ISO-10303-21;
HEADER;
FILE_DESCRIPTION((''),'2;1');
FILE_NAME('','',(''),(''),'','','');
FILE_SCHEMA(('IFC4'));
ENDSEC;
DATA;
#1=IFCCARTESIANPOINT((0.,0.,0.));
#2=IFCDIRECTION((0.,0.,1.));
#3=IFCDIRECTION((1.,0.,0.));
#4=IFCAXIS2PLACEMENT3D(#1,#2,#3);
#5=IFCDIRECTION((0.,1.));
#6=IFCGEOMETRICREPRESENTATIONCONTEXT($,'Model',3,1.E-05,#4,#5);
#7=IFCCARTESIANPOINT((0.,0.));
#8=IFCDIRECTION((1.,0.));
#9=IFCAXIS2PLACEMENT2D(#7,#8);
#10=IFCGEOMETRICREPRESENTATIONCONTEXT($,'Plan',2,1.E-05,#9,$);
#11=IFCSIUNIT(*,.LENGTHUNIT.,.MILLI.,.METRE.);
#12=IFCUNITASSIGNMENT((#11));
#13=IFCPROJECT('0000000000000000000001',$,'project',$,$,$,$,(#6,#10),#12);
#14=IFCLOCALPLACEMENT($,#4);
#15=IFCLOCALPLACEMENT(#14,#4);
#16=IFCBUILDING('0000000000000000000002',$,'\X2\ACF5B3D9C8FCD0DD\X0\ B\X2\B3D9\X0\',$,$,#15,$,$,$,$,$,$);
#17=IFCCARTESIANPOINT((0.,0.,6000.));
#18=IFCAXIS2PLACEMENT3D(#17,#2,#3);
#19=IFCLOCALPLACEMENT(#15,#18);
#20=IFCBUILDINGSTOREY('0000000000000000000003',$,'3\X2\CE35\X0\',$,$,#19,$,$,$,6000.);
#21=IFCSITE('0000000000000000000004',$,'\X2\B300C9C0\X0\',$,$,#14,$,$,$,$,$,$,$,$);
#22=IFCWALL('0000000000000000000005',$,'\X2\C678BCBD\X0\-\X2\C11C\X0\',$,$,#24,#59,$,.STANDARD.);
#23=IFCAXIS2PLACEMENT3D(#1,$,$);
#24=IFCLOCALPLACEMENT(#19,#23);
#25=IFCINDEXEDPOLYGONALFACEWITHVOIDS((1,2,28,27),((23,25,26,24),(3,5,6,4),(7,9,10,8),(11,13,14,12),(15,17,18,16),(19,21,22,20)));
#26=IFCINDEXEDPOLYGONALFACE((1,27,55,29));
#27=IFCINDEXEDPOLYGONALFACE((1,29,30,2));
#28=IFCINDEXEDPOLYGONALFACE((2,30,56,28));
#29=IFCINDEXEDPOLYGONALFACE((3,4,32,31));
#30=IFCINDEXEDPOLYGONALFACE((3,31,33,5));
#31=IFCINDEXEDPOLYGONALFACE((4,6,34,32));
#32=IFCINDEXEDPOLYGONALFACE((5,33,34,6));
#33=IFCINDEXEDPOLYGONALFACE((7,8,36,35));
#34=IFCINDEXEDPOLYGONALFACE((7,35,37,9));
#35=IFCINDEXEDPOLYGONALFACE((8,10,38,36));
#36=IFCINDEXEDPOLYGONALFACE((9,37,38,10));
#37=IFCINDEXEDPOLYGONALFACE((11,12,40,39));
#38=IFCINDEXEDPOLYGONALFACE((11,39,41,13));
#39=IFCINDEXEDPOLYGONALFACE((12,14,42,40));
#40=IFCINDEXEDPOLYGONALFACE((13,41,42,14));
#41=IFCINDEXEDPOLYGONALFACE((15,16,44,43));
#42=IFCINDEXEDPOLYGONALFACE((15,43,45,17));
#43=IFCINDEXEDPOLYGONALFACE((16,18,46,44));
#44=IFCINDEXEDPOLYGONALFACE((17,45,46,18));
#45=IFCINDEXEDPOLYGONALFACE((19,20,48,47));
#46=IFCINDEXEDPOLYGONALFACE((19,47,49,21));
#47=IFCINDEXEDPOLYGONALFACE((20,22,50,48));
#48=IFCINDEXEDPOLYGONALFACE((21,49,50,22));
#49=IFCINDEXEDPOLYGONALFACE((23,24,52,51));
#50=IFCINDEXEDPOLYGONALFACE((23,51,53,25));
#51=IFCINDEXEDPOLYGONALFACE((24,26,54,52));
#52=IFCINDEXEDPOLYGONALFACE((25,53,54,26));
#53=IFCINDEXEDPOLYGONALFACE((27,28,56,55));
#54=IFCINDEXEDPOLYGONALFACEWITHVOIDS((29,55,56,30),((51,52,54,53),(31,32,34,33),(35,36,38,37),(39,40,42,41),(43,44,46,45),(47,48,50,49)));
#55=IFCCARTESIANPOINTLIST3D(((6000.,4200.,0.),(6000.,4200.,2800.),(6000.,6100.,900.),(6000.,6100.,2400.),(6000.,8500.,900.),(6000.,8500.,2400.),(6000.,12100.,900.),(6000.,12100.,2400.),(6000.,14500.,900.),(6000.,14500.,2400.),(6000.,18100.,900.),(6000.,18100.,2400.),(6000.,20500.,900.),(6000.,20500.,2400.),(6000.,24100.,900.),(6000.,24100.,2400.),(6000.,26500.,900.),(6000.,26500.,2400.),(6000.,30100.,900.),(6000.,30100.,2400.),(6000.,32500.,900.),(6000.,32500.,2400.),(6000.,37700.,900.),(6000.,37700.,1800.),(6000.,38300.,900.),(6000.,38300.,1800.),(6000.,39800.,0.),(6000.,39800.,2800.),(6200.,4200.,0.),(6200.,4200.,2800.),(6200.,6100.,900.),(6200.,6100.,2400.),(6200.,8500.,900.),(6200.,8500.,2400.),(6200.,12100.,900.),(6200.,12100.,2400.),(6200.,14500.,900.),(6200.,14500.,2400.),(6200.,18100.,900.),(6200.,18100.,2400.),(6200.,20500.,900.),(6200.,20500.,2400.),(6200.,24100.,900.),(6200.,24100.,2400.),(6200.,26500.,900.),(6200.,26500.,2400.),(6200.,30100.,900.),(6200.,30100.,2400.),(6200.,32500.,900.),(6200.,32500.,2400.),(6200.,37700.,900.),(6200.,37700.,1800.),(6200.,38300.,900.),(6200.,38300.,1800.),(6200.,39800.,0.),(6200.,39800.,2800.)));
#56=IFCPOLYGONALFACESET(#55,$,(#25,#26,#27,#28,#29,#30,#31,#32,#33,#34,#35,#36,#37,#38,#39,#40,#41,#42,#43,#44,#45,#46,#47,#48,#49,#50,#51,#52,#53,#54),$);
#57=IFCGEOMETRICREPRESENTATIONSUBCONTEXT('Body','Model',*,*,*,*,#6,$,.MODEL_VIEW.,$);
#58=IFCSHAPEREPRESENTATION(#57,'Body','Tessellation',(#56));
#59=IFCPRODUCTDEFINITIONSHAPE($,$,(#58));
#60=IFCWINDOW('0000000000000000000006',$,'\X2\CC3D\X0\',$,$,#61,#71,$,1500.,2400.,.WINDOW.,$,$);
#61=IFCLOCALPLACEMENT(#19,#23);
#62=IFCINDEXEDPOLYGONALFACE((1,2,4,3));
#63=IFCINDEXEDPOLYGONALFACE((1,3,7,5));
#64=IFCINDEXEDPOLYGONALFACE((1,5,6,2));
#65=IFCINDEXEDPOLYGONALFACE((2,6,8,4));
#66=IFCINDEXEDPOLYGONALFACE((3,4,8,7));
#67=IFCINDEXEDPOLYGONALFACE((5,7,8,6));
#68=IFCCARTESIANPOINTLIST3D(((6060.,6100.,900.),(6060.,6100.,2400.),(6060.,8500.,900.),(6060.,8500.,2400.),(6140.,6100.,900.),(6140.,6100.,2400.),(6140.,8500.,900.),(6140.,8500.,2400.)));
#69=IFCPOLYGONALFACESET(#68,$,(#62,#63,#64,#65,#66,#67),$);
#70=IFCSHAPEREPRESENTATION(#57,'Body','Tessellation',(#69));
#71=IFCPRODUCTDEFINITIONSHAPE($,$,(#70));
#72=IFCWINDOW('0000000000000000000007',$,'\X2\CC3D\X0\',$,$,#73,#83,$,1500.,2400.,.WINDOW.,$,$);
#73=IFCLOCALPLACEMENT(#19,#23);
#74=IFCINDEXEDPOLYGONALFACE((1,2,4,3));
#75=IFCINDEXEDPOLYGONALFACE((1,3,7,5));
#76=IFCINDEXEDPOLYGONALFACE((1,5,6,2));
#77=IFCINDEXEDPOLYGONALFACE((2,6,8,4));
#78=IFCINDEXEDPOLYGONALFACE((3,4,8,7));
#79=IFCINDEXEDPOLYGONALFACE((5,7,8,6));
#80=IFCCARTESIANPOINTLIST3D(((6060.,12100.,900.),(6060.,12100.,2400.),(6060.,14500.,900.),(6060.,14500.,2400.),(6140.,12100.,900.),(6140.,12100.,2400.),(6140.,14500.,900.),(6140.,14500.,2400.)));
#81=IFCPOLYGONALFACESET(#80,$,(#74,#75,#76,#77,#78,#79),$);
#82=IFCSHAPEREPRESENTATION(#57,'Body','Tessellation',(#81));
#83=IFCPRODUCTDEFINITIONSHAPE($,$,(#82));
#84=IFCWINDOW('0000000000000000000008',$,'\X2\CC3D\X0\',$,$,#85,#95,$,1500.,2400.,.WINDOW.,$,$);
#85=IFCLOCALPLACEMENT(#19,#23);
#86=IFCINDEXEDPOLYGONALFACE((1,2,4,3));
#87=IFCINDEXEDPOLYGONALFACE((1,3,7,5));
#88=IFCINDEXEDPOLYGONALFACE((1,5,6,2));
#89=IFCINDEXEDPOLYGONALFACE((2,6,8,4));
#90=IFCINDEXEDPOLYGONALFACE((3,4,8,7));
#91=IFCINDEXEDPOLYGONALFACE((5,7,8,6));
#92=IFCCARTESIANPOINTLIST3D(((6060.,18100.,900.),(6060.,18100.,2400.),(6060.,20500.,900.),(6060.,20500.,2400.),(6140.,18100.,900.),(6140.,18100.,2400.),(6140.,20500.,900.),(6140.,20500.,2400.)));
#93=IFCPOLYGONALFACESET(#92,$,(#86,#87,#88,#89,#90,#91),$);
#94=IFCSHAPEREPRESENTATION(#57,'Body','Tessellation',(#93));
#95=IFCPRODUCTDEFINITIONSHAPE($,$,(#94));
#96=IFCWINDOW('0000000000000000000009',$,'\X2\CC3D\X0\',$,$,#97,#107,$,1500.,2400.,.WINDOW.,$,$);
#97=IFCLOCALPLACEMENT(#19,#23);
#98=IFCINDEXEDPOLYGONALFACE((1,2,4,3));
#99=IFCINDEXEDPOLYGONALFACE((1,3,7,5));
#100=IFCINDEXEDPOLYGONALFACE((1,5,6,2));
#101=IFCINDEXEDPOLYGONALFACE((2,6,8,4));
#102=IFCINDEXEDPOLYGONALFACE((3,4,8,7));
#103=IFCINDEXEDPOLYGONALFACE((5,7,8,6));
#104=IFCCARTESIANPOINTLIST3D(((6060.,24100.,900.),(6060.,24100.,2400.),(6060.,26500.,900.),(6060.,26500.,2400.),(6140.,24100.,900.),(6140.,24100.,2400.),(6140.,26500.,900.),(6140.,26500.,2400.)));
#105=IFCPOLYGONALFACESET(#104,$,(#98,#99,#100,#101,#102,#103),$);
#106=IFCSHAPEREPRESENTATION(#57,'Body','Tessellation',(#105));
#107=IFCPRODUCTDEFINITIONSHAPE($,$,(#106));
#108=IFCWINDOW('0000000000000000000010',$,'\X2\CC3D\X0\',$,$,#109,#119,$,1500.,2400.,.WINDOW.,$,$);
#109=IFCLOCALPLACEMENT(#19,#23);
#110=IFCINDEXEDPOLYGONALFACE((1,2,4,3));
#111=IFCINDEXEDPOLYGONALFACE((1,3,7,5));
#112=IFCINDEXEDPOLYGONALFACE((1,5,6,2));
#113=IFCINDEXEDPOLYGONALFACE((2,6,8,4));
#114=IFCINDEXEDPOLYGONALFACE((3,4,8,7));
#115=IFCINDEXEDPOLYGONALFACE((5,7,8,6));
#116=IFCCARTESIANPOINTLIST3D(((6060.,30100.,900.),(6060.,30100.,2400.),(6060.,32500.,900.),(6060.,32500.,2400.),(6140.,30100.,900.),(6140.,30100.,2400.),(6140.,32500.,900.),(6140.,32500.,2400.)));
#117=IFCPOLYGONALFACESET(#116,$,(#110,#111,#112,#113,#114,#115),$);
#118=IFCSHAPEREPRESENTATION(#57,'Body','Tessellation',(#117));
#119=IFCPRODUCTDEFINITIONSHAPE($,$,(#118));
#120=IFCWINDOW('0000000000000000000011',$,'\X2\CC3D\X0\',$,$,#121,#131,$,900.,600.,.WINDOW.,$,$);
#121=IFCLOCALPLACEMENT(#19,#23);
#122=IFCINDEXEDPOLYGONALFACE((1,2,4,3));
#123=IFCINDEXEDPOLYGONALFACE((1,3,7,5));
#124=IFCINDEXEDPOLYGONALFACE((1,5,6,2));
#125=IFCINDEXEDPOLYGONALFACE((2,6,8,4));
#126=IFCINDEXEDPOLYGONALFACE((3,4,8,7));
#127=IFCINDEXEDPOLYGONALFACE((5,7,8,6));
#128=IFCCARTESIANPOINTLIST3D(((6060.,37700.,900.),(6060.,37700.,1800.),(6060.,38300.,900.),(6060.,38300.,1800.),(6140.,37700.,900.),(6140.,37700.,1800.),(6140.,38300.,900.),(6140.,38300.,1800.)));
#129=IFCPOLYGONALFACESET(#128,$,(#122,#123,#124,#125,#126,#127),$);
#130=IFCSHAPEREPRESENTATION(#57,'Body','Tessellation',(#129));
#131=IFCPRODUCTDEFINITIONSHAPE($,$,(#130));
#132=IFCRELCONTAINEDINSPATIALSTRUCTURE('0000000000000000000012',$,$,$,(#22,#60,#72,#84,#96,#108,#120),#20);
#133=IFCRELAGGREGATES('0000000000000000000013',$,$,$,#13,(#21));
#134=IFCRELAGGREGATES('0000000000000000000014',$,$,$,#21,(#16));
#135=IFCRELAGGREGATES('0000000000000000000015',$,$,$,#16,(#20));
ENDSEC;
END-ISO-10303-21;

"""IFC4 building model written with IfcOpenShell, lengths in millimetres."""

from ifc_helpers import new_model, si_unit, direction, frame, origin_with_axes, origin_2d_with_axis, place, context, subcontext, project, spatial, polyline, outline, extrude, element, fill, save


model = new_model("IFC4")

# Units and contexts
model_context = context("Model", 3, precision=1e-05, world=origin_with_axes(), true_north=direction((0.0, 1.0)))
plan_context = context("Plan", 2, precision=1e-05, world=origin_2d_with_axis())
body_context = subcontext(model_context, "Body", "Model", "MODEL_VIEW")
ifc_project = project(units=[si_unit("LENGTHUNIT", "METRE", prefix="MILLI")], contexts=[model_context, plan_context])

# Site, building, storey
site_placement = place(None, origin_with_axes())
site = spatial("IfcSite", under=ifc_project, at=site_placement, Name="대지")
building_placement = place(site_placement, origin_with_axes())
building = spatial("IfcBuilding", under=site, at=building_placement, Name="공동주택 B동")
storey_placement = place(building_placement, frame((0.0, 0.0, 6000.0), z_axis=(0.0, 0.0, 1.0), x_axis=(1.0, 0.0, 0.0)))
storey = spatial("IfcBuildingStorey", under=building, at=storey_placement, Name="3층", Elevation=6000.0)

# Wall, openings, windows
wall_1_placement = place(storey_placement, origin_with_axes())
wall_1 = element("IfcWall", 1, at=wall_1_placement, inside=storey, Name="외벽-서", PredefinedType="STANDARD", context=body_context, shape_type="SweptSolid", body=[
    extrude(outline(polyline([(6200.0, 39800.0), (6200.0, 4200.0), (6000.0, 4200.0), (6000.0, 39800.0), (6200.0, 39800.0)])), origin_with_axes(), (0.0, 0.0, 1.0), 2800.0),
])
opening_1_placement = place(storey_placement, origin_with_axes())
opening_1 = element("IfcOpeningElement", 2, at=opening_1_placement, cuts=wall_1, PredefinedType="OPENING", context=body_context, shape_type="SweptSolid", body=[
    extrude(outline(polyline([(5950.0, 8500.0), (5950.0, 6100.0), (6250.0, 6100.0), (6250.0, 8500.0), (5950.0, 8500.0)])), frame((0.0, 0.0, 900.0), z_axis=(0.0, 0.0, 1.0), x_axis=(1.0, 0.0, 0.0)), (0.0, 0.0, 1.0), 1500.0),
])
opening_2_placement = place(storey_placement, origin_with_axes())
opening_2 = element("IfcOpeningElement", 3, at=opening_2_placement, cuts=wall_1, PredefinedType="OPENING", context=body_context, shape_type="SweptSolid", body=[
    extrude(outline(polyline([(5950.0, 14500.0), (5950.0, 12100.0), (6250.0, 12100.0), (6250.0, 14500.0), (5950.0, 14500.0)])), frame((0.0, 0.0, 900.0), z_axis=(0.0, 0.0, 1.0), x_axis=(1.0, 0.0, 0.0)), (0.0, 0.0, 1.0), 1500.0),
])
opening_3_placement = place(storey_placement, origin_with_axes())
opening_3 = element("IfcOpeningElement", 4, at=opening_3_placement, cuts=wall_1, PredefinedType="OPENING", context=body_context, shape_type="SweptSolid", body=[
    extrude(outline(polyline([(5950.0, 20500.0), (5950.0, 18100.0), (6250.0, 18100.0), (6250.0, 20500.0), (5950.0, 20500.0)])), frame((0.0, 0.0, 900.0), z_axis=(0.0, 0.0, 1.0), x_axis=(1.0, 0.0, 0.0)), (0.0, 0.0, 1.0), 1500.0),
])
opening_4_placement = place(storey_placement, origin_with_axes())
opening_4 = element("IfcOpeningElement", 5, at=opening_4_placement, cuts=wall_1, PredefinedType="OPENING", context=body_context, shape_type="SweptSolid", body=[
    extrude(outline(polyline([(5950.0, 26500.0), (5950.0, 24100.0), (6250.0, 24100.0), (6250.0, 26500.0), (5950.0, 26500.0)])), frame((0.0, 0.0, 900.0), z_axis=(0.0, 0.0, 1.0), x_axis=(1.0, 0.0, 0.0)), (0.0, 0.0, 1.0), 1500.0),
])
opening_5_placement = place(storey_placement, origin_with_axes())
opening_5 = element("IfcOpeningElement", 6, at=opening_5_placement, cuts=wall_1, PredefinedType="OPENING", context=body_context, shape_type="SweptSolid", body=[
    extrude(outline(polyline([(5950.0, 32500.0), (5950.0, 30100.0), (6250.0, 30100.0), (6250.0, 32500.0), (5950.0, 32500.0)])), frame((0.0, 0.0, 900.0), z_axis=(0.0, 0.0, 1.0), x_axis=(1.0, 0.0, 0.0)), (0.0, 0.0, 1.0), 1500.0),
])
opening_6_placement = place(storey_placement, origin_with_axes())
opening_6 = element("IfcOpeningElement", 7, at=opening_6_placement, cuts=wall_1, PredefinedType="OPENING", context=body_context, shape_type="SweptSolid", body=[
    extrude(outline(polyline([(5950.0, 38300.0), (5950.0, 37700.0), (6250.0, 37700.0), (6250.0, 38300.0), (5950.0, 38300.0)])), frame((0.0, 0.0, 900.0), z_axis=(0.0, 0.0, 1.0), x_axis=(1.0, 0.0, 0.0)), (0.0, 0.0, 1.0), 900.0),
])
window_1_placement = place(storey_placement, origin_with_axes())
window_1 = element("IfcWindow", 8, at=window_1_placement, inside=storey, Name="창", OverallHeight=1500.0, OverallWidth=2400.0, PredefinedType="WINDOW", context=body_context, shape_type="SweptSolid", body=[
    extrude(outline(polyline([(6060.0, 8500.0), (6060.0, 6100.0), (6140.0, 6100.0), (6140.0, 8500.0), (6060.0, 8500.0)])), frame((0.0, 0.0, 900.0), z_axis=(0.0, 0.0, 1.0), x_axis=(1.0, 0.0, 0.0)), (0.0, 0.0, 1.0), 1500.0),
])
fill(opening_1, window_1)
window_2_placement = place(storey_placement, origin_with_axes())
window_2 = element("IfcWindow", 9, at=window_2_placement, inside=storey, Name="창", OverallHeight=1500.0, OverallWidth=2400.0, PredefinedType="WINDOW", context=body_context, shape_type="SweptSolid", body=[
    extrude(outline(polyline([(6060.0, 14500.0), (6060.0, 12100.0), (6140.0, 12100.0), (6140.0, 14500.0), (6060.0, 14500.0)])), frame((0.0, 0.0, 900.0), z_axis=(0.0, 0.0, 1.0), x_axis=(1.0, 0.0, 0.0)), (0.0, 0.0, 1.0), 1500.0),
])
fill(opening_2, window_2)
window_3_placement = place(storey_placement, origin_with_axes())
window_3 = element("IfcWindow", 10, at=window_3_placement, inside=storey, Name="창", OverallHeight=1500.0, OverallWidth=2400.0, PredefinedType="WINDOW", context=body_context, shape_type="SweptSolid", body=[
    extrude(outline(polyline([(6060.0, 20500.0), (6060.0, 18100.0), (6140.0, 18100.0), (6140.0, 20500.0), (6060.0, 20500.0)])), frame((0.0, 0.0, 900.0), z_axis=(0.0, 0.0, 1.0), x_axis=(1.0, 0.0, 0.0)), (0.0, 0.0, 1.0), 1500.0),
])
fill(opening_3, window_3)
window_4_placement = place(storey_placement, origin_with_axes())
window_4 = element("IfcWindow", 11, at=window_4_placement, inside=storey, Name="창", OverallHeight=1500.0, OverallWidth=2400.0, PredefinedType="WINDOW", context=body_context, shape_type="SweptSolid", body=[
    extrude(outline(polyline([(6060.0, 26500.0), (6060.0, 24100.0), (6140.0, 24100.0), (6140.0, 26500.0), (6060.0, 26500.0)])), frame((0.0, 0.0, 900.0), z_axis=(0.0, 0.0, 1.0), x_axis=(1.0, 0.0, 0.0)), (0.0, 0.0, 1.0), 1500.0),
])
fill(opening_4, window_4)
window_5_placement = place(storey_placement, origin_with_axes())
window_5 = element("IfcWindow", 12, at=window_5_placement, inside=storey, Name="창", OverallHeight=1500.0, OverallWidth=2400.0, PredefinedType="WINDOW", context=body_context, shape_type="SweptSolid", body=[
    extrude(outline(polyline([(6060.0, 32500.0), (6060.0, 30100.0), (6140.0, 30100.0), (6140.0, 32500.0), (6060.0, 32500.0)])), frame((0.0, 0.0, 900.0), z_axis=(0.0, 0.0, 1.0), x_axis=(1.0, 0.0, 0.0)), (0.0, 0.0, 1.0), 1500.0),
])
fill(opening_5, window_5)
window_6_placement = place(storey_placement, origin_with_axes())
window_6 = element("IfcWindow", 13, at=window_6_placement, inside=storey, Name="창", OverallHeight=900.0, OverallWidth=600.0, PredefinedType="WINDOW", context=body_context, shape_type="SweptSolid", body=[
    extrude(outline(polyline([(6060.0, 38300.0), (6060.0, 37700.0), (6140.0, 37700.0), (6140.0, 38300.0), (6060.0, 38300.0)])), frame((0.0, 0.0, 900.0), z_axis=(0.0, 0.0, 1.0), x_axis=(1.0, 0.0, 0.0)), (0.0, 0.0, 1.0), 900.0),
])
fill(opening_6, window_6)

save(model, "model.ifc")
